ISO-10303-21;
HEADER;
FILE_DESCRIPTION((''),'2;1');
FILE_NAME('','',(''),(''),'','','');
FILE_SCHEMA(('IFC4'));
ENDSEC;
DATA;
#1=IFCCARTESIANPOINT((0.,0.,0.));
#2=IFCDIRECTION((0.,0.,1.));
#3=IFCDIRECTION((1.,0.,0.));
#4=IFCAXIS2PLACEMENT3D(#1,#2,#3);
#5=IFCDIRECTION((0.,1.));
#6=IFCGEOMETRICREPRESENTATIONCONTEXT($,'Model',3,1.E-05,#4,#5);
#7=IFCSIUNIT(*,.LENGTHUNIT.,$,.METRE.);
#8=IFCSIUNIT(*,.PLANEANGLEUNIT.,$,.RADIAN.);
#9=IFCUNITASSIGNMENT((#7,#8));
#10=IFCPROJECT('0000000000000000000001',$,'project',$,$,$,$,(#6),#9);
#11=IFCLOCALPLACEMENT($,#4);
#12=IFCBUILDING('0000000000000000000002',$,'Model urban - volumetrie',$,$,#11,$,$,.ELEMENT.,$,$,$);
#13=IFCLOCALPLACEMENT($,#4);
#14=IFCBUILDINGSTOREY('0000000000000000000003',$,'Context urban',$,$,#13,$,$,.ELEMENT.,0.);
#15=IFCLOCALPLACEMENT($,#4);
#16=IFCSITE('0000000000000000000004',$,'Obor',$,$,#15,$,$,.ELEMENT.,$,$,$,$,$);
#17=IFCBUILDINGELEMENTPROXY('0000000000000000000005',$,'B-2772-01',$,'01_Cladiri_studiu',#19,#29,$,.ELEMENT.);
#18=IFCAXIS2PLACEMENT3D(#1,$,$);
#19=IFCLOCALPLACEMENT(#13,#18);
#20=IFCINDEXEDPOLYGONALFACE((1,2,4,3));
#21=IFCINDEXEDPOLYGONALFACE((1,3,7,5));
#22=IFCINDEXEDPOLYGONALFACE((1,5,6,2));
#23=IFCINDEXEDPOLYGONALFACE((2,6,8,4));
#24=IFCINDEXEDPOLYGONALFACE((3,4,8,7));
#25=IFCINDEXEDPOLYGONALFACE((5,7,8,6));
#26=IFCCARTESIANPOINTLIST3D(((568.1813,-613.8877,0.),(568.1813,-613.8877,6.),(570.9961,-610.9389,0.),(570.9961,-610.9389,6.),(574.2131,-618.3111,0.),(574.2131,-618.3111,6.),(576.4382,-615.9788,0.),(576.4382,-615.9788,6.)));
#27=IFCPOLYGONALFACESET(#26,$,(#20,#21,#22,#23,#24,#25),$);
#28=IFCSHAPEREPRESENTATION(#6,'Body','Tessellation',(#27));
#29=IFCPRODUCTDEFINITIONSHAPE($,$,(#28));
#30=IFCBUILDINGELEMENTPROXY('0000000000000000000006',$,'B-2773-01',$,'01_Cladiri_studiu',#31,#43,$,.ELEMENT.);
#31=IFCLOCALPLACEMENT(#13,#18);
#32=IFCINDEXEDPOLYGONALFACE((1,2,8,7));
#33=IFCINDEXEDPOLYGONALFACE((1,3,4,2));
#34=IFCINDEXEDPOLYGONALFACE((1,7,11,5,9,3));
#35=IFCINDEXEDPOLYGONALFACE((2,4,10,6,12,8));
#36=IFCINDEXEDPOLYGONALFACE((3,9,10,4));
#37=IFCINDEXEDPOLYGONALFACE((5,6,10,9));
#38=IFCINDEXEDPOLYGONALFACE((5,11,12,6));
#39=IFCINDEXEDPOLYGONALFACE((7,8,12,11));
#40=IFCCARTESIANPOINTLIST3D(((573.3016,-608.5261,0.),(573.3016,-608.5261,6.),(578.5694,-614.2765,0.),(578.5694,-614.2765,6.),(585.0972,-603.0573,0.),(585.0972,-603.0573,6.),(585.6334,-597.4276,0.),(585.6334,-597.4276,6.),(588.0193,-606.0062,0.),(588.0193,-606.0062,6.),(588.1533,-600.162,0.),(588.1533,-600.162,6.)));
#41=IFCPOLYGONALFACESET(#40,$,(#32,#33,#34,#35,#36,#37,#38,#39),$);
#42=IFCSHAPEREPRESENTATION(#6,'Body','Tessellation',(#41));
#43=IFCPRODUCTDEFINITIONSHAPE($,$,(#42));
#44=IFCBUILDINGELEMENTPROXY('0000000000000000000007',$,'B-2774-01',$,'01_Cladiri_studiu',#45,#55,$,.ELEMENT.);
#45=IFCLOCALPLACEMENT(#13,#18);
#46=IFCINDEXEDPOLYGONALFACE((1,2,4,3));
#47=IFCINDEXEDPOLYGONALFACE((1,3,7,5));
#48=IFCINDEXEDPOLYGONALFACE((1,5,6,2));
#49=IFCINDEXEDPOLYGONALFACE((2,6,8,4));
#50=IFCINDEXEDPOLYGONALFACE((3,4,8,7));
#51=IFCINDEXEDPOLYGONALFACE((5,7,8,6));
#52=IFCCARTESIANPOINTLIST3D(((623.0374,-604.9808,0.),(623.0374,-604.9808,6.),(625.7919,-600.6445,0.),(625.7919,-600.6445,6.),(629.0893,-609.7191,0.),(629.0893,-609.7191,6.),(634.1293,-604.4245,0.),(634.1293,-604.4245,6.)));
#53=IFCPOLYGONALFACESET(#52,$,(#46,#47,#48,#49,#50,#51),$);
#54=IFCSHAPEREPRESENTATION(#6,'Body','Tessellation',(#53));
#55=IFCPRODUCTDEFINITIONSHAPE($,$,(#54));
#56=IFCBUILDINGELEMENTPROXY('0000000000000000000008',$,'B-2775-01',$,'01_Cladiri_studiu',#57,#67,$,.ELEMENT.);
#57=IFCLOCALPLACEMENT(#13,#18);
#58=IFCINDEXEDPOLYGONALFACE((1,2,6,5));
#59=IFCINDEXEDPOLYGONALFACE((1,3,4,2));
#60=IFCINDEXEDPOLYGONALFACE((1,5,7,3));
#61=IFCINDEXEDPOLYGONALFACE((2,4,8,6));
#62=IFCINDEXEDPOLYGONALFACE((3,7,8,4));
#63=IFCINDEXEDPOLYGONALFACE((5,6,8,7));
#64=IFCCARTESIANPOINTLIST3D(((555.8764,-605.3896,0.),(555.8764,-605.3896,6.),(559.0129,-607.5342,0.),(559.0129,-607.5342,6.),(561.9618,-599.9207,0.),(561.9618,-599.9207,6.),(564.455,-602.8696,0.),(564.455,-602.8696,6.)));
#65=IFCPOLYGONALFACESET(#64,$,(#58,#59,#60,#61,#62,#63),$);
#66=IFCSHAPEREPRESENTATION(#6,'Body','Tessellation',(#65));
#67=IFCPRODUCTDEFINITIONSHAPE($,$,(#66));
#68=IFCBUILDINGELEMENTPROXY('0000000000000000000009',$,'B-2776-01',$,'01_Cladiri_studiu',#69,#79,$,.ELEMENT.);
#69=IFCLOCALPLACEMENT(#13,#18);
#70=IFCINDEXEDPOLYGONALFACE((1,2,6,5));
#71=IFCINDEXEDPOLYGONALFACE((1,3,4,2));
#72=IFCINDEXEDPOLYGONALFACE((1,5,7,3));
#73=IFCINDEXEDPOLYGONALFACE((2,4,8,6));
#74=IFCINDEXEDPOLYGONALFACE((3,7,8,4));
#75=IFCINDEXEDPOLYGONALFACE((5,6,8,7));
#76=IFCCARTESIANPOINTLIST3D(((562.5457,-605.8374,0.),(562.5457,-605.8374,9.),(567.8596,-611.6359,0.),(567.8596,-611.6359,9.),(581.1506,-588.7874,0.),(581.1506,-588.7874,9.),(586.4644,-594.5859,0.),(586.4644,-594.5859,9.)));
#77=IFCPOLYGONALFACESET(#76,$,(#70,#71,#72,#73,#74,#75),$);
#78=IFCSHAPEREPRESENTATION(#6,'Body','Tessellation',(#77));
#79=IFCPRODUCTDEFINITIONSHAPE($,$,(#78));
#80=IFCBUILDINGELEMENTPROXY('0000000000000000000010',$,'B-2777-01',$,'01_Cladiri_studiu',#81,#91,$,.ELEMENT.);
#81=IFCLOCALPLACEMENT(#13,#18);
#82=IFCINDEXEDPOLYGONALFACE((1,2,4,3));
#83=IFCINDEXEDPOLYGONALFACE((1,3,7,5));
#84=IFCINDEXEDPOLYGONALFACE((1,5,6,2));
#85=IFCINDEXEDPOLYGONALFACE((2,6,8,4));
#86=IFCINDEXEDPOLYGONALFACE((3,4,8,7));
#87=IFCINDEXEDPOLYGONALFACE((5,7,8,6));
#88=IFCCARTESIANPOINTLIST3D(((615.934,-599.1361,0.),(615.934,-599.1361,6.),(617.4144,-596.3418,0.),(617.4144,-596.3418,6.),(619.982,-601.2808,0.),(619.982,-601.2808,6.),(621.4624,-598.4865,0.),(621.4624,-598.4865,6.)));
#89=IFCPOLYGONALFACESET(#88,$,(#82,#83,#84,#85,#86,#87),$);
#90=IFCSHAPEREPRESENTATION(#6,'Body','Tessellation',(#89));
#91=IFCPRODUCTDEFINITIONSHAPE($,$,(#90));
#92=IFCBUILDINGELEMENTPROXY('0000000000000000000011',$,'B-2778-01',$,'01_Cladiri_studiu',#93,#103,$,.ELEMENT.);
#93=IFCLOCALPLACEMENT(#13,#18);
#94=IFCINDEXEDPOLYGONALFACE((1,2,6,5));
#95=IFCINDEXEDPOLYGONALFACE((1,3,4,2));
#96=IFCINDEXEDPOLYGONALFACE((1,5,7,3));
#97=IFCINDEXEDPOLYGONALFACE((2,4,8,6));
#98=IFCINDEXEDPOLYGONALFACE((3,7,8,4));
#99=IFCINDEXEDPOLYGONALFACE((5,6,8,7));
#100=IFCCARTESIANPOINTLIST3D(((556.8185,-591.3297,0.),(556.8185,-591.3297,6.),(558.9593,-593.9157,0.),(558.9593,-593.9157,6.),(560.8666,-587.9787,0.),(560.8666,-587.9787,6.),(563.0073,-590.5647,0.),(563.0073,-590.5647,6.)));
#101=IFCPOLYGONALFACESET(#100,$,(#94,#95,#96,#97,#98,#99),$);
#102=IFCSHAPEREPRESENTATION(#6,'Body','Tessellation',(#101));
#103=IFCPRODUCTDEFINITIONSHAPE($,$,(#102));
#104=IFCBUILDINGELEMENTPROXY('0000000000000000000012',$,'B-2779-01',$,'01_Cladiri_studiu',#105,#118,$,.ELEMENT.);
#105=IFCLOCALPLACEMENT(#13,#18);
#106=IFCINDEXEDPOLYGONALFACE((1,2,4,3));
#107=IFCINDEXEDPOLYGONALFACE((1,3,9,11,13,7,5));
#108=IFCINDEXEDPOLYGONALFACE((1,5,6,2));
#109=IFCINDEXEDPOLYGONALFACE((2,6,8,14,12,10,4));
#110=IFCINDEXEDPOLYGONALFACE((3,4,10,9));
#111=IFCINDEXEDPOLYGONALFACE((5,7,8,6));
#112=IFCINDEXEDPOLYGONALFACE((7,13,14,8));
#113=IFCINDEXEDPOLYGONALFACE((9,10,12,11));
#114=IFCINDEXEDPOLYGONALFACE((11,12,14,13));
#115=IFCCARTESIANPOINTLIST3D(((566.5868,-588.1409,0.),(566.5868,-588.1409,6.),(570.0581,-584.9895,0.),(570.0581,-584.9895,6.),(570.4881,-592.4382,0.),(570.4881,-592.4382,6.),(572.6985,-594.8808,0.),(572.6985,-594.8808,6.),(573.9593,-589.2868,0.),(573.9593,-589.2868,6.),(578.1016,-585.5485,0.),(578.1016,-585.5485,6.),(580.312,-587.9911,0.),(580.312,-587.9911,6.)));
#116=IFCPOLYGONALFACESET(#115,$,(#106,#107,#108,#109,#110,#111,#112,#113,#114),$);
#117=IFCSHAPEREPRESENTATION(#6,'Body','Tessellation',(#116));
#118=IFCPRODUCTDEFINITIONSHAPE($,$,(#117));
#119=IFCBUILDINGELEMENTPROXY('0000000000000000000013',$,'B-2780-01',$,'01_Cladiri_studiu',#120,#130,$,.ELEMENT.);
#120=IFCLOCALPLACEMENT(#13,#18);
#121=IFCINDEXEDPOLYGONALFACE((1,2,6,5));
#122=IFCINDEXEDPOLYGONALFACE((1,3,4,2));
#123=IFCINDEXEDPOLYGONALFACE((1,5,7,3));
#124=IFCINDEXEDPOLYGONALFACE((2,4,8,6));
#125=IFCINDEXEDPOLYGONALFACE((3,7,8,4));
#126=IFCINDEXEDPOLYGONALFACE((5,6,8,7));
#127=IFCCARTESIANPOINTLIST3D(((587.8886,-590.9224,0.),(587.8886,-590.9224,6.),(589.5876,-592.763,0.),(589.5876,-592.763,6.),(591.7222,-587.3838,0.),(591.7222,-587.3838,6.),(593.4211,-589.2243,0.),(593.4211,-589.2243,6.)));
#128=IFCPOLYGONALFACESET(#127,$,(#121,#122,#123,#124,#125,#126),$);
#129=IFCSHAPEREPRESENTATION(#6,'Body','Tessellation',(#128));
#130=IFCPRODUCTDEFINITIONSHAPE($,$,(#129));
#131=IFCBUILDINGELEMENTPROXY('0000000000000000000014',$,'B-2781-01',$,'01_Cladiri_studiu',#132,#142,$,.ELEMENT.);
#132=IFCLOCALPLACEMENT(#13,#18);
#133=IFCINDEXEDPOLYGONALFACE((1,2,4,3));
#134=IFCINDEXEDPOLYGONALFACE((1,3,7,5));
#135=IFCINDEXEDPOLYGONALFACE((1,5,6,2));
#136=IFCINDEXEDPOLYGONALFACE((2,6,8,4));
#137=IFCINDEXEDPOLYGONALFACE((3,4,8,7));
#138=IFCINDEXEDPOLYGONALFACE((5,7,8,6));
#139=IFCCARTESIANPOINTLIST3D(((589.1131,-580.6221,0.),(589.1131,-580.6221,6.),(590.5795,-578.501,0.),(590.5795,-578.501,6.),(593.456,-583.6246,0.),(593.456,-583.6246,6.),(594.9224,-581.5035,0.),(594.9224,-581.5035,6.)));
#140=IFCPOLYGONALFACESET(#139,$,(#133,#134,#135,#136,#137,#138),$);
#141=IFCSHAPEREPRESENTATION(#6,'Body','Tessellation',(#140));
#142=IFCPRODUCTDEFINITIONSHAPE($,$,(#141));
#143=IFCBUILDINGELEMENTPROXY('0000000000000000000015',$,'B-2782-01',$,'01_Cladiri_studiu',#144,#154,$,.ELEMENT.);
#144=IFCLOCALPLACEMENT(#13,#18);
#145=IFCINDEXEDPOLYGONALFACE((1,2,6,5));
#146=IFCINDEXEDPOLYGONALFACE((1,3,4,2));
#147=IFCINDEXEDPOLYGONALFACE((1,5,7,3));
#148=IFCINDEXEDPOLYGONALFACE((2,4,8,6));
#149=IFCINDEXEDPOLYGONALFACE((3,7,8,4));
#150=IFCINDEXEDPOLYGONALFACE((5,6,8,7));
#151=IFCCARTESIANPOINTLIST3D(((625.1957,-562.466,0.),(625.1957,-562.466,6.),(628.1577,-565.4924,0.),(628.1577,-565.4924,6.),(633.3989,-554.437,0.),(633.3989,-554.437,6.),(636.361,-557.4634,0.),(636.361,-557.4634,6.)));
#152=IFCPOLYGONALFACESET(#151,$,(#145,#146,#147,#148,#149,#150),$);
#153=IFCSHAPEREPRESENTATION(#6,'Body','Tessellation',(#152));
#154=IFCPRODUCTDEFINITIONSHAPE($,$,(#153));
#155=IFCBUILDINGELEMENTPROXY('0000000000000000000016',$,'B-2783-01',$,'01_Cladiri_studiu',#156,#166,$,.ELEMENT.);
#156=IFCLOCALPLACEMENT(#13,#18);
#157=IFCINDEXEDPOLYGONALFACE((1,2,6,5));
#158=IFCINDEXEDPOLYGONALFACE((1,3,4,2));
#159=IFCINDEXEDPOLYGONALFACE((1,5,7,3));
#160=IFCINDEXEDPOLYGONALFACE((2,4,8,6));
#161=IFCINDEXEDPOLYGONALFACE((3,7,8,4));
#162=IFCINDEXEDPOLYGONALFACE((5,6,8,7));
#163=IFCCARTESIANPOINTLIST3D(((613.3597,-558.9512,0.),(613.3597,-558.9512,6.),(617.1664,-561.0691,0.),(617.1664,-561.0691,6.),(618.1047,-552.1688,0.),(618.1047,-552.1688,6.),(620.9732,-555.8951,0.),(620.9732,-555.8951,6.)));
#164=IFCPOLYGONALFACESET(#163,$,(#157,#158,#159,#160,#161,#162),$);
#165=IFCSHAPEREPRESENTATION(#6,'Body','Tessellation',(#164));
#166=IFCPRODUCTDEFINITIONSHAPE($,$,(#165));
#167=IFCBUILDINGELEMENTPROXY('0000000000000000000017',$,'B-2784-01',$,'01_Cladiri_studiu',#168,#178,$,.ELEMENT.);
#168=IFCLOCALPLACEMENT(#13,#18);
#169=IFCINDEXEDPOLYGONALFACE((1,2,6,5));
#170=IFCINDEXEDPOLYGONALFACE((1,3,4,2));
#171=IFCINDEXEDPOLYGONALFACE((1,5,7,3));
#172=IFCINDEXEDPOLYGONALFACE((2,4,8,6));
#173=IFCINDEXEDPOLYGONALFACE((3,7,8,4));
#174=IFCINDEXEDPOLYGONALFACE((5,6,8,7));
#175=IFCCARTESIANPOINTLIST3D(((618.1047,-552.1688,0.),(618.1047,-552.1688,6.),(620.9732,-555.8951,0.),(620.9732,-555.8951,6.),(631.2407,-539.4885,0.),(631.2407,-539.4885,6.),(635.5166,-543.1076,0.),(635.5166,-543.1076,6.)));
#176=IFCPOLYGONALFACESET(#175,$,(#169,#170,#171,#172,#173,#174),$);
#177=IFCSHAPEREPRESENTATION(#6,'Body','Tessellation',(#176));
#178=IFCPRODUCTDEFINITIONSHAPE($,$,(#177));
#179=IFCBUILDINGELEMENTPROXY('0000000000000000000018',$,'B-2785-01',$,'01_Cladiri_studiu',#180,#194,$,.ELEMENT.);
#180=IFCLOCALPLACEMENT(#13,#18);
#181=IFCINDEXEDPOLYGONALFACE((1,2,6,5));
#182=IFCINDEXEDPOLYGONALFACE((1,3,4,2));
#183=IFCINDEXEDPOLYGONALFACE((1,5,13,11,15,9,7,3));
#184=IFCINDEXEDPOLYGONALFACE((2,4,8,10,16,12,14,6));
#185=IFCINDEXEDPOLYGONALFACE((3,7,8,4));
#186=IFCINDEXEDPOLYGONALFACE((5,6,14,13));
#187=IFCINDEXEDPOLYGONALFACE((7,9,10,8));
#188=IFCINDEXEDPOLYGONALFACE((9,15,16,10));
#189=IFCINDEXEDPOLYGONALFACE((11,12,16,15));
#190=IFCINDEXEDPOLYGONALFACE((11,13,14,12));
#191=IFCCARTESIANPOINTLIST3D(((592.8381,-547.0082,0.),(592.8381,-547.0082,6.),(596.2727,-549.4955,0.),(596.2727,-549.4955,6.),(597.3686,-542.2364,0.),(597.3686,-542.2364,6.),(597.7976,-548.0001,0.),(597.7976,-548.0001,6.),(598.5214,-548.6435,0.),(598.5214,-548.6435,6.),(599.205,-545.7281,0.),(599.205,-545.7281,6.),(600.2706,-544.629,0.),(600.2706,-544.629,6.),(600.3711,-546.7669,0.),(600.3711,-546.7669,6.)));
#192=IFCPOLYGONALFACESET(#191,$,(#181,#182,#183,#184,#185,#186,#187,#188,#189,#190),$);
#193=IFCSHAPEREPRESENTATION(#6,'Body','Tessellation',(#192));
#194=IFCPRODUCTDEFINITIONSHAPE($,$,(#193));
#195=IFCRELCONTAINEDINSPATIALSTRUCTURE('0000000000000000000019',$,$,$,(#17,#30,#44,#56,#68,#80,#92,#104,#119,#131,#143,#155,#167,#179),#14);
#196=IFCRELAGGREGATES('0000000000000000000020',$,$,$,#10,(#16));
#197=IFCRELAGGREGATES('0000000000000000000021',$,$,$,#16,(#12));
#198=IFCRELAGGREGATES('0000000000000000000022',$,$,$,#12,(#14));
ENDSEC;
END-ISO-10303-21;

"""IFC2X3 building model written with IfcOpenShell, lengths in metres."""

from ifc_helpers import new_model, si_unit, direction, origin_with_axes, place, context, project, spatial, polyline, outline, extrude, element, save


model = new_model("IFC2X3")

# Units and contexts
model_context = context("Model", 3, precision=1e-05, world=origin_with_axes(), true_north=direction((0.0, 1.0)))
ifc_project = project(units=[si_unit("LENGTHUNIT", "METRE"), si_unit("PLANEANGLEUNIT", "RADIAN")], contexts=[model_context])

# Site, building, storey
site_placement = place(None, origin_with_axes())
site = spatial("IfcSite", under=ifc_project, at=site_placement, Name="Obor", CompositionType="ELEMENT")
building_placement = place(None, origin_with_axes())
building = spatial("IfcBuilding", under=site, at=building_placement, Name="Model urban - volumetrie", CompositionType="ELEMENT")
storey_placement = place(None, origin_with_axes())
storey = spatial("IfcBuildingStorey", under=building, at=storey_placement, Name="Context urban", CompositionType="ELEMENT", Elevation=0.0)

# Building element proxies
proxy_1_placement = place(None, origin_with_axes())
element("IfcBuildingElementProxy", 1, at=proxy_1_placement, inside=storey, Name="B-2772-01", ObjectType="01_Cladiri_studiu", CompositionType="ELEMENT", context=model_context, shape_type="SweptSolid", body=[
    extrude(outline(polyline([(574.2131, -618.3111), (576.4382, -615.9788), (570.9961, -610.9389), (568.1813, -613.8877), (574.2131, -618.3111)])), origin_with_axes(), (0.0, 0.0, 1.0), 6.0),
])
proxy_2_placement = place(None, origin_with_axes())
element("IfcBuildingElementProxy", 2, at=proxy_2_placement, inside=storey, Name="B-2773-01", ObjectType="01_Cladiri_studiu", CompositionType="ELEMENT", context=model_context, shape_type="SweptSolid", body=[
    extrude(outline(polyline([(585.0972, -603.0573), (588.1533, -600.162), (585.6334, -597.4276), (573.3016, -608.5261), (578.5694, -614.2765), (588.0193, -606.0062), (585.0972, -603.0573)])), origin_with_axes(), (0.0, 0.0, 1.0), 6.0),
])
proxy_3_placement = place(None, origin_with_axes())
element("IfcBuildingElementProxy", 3, at=proxy_3_placement, inside=storey, Name="B-2774-01", ObjectType="01_Cladiri_studiu", CompositionType="ELEMENT", context=model_context, shape_type="SweptSolid", body=[
    extrude(outline(polyline([(629.0893, -609.7191), (634.1293, -604.4245), (625.7919, -600.6445), (623.0374, -604.9808), (629.0893, -609.7191)])), origin_with_axes(), (0.0, 0.0, 1.0), 6.0),
])
proxy_4_placement = place(None, origin_with_axes())
element("IfcBuildingElementProxy", 4, at=proxy_4_placement, inside=storey, Name="B-2775-01", ObjectType="01_Cladiri_studiu", CompositionType="ELEMENT", context=model_context, shape_type="SweptSolid", body=[
    extrude(outline(polyline([(564.455, -602.8696), (561.9618, -599.9207), (555.8764, -605.3896), (559.0129, -607.5342), (564.455, -602.8696)])), origin_with_axes(), (0.0, 0.0, 1.0), 6.0),
])
proxy_5_placement = place(None, origin_with_axes())
element("IfcBuildingElementProxy", 5, at=proxy_5_placement, inside=storey, Name="B-2776-01", ObjectType="01_Cladiri_studiu", CompositionType="ELEMENT", context=model_context, shape_type="SweptSolid", body=[
    extrude(outline(polyline([(581.1506, -588.7874), (562.5457, -605.8374), (567.8596, -611.6359), (586.4644, -594.5859), (581.1506, -588.7874)])), origin_with_axes(), (0.0, 0.0, 1.0), 9.0),
])
proxy_6_placement = place(None, origin_with_axes())
element("IfcBuildingElementProxy", 6, at=proxy_6_placement, inside=storey, Name="B-2777-01", ObjectType="01_Cladiri_studiu", CompositionType="ELEMENT", context=model_context, shape_type="SweptSolid", body=[
    extrude(outline(polyline([(619.982, -601.2808), (621.4624, -598.4865), (617.4144, -596.3418), (615.934, -599.1361), (619.982, -601.2808)])), origin_with_axes(), (0.0, 0.0, 1.0), 6.0),
])
proxy_7_placement = place(None, origin_with_axes())
element("IfcBuildingElementProxy", 7, at=proxy_7_placement, inside=storey, Name="B-2778-01", ObjectType="01_Cladiri_studiu", CompositionType="ELEMENT", context=model_context, shape_type="SweptSolid", body=[
    extrude(outline(polyline([(563.0073, -590.5647), (560.8666, -587.9787), (556.8185, -591.3297), (558.9593, -593.9157), (563.0073, -590.5647)])), origin_with_axes(), (0.0, 0.0, 1.0), 6.0),
])
proxy_8_placement = place(None, origin_with_axes())
element("IfcBuildingElementProxy", 8, at=proxy_8_placement, inside=storey, Name="B-2779-01", ObjectType="01_Cladiri_studiu", CompositionType="ELEMENT", context=model_context, shape_type="SweptSolid", body=[
    extrude(outline(polyline([(566.5868, -588.1409), (570.4881, -592.4382), (572.6985, -594.8808), (580.312, -587.9911), (578.1016, -585.5485), (573.9593, -589.2868), (570.0581, -584.9895), (566.5868, -588.1409)])), origin_with_axes(), (0.0, 0.0, 1.0), 6.0),
])
proxy_9_placement = place(None, origin_with_axes())
element("IfcBuildingElementProxy", 9, at=proxy_9_placement, inside=storey, Name="B-2780-01", ObjectType="01_Cladiri_studiu", CompositionType="ELEMENT", context=model_context, shape_type="SweptSolid", body=[
    extrude(outline(polyline([(591.7222, -587.3838), (587.8886, -590.9224), (589.5876, -592.763), (593.4211, -589.2243), (591.7222, -587.3838)])), origin_with_axes(), (0.0, 0.0, 1.0), 6.0),
])
proxy_10_placement = place(None, origin_with_axes())
element("IfcBuildingElementProxy", 10, at=proxy_10_placement, inside=storey, Name="B-2781-01", ObjectType="01_Cladiri_studiu", CompositionType="ELEMENT", context=model_context, shape_type="SweptSolid", body=[
    extrude(outline(polyline([(589.1131, -580.6221), (593.456, -583.6246), (594.9224, -581.5035), (590.5795, -578.501), (589.1131, -580.6221)])), origin_with_axes(), (0.0, 0.0, 1.0), 6.0),
])
proxy_11_placement = place(None, origin_with_axes())
element("IfcBuildingElementProxy", 11, at=proxy_11_placement, inside=storey, Name="B-2782-01", ObjectType="01_Cladiri_studiu", CompositionType="ELEMENT", context=model_context, shape_type="SweptSolid", body=[
    extrude(outline(polyline([(636.361, -557.4634), (633.3989, -554.437), (625.1957, -562.466), (628.1577, -565.4924), (636.361, -557.4634)])), origin_with_axes(), (0.0, 0.0, 1.0), 6.0),
])
proxy_12_placement = place(None, origin_with_axes())
element("IfcBuildingElementProxy", 12, at=proxy_12_placement, inside=storey, Name="B-2783-01", ObjectType="01_Cladiri_studiu", CompositionType="ELEMENT", context=model_context, shape_type="SweptSolid", body=[
    extrude(outline(polyline([(620.9732, -555.8951), (618.1047, -552.1688), (613.3597, -558.9512), (617.1664, -561.0691), (620.9732, -555.8951)])), origin_with_axes(), (0.0, 0.0, 1.0), 6.0),
])
proxy_13_placement = place(None, origin_with_axes())
element("IfcBuildingElementProxy", 13, at=proxy_13_placement, inside=storey, Name="B-2784-01", ObjectType="01_Cladiri_studiu", CompositionType="ELEMENT", context=model_context, shape_type="SweptSolid", body=[
    extrude(outline(polyline([(635.5166, -543.1076), (631.2407, -539.4885), (618.1047, -552.1688), (620.9732, -555.8951), (635.5166, -543.1076)])), origin_with_axes(), (0.0, 0.0, 1.0), 6.0),
])
proxy_14_placement = place(None, origin_with_axes())
element("IfcBuildingElementProxy", 14, at=proxy_14_placement, inside=storey, Name="B-2785-01", ObjectType="01_Cladiri_studiu", CompositionType="ELEMENT", context=model_context, shape_type="SweptSolid", body=[
    extrude(outline(polyline([(596.2727, -549.4955), (597.7976, -548.0001), (598.5214, -548.6435), (600.3711, -546.7669), (599.205, -545.7281), (600.2706, -544.629), (597.3686, -542.2364), (592.8381, -547.0082), (596.2727, -549.4955)])), origin_with_axes(), (0.0, 0.0, 1.0), 6.0),
])

save(model, "model.ifc")
